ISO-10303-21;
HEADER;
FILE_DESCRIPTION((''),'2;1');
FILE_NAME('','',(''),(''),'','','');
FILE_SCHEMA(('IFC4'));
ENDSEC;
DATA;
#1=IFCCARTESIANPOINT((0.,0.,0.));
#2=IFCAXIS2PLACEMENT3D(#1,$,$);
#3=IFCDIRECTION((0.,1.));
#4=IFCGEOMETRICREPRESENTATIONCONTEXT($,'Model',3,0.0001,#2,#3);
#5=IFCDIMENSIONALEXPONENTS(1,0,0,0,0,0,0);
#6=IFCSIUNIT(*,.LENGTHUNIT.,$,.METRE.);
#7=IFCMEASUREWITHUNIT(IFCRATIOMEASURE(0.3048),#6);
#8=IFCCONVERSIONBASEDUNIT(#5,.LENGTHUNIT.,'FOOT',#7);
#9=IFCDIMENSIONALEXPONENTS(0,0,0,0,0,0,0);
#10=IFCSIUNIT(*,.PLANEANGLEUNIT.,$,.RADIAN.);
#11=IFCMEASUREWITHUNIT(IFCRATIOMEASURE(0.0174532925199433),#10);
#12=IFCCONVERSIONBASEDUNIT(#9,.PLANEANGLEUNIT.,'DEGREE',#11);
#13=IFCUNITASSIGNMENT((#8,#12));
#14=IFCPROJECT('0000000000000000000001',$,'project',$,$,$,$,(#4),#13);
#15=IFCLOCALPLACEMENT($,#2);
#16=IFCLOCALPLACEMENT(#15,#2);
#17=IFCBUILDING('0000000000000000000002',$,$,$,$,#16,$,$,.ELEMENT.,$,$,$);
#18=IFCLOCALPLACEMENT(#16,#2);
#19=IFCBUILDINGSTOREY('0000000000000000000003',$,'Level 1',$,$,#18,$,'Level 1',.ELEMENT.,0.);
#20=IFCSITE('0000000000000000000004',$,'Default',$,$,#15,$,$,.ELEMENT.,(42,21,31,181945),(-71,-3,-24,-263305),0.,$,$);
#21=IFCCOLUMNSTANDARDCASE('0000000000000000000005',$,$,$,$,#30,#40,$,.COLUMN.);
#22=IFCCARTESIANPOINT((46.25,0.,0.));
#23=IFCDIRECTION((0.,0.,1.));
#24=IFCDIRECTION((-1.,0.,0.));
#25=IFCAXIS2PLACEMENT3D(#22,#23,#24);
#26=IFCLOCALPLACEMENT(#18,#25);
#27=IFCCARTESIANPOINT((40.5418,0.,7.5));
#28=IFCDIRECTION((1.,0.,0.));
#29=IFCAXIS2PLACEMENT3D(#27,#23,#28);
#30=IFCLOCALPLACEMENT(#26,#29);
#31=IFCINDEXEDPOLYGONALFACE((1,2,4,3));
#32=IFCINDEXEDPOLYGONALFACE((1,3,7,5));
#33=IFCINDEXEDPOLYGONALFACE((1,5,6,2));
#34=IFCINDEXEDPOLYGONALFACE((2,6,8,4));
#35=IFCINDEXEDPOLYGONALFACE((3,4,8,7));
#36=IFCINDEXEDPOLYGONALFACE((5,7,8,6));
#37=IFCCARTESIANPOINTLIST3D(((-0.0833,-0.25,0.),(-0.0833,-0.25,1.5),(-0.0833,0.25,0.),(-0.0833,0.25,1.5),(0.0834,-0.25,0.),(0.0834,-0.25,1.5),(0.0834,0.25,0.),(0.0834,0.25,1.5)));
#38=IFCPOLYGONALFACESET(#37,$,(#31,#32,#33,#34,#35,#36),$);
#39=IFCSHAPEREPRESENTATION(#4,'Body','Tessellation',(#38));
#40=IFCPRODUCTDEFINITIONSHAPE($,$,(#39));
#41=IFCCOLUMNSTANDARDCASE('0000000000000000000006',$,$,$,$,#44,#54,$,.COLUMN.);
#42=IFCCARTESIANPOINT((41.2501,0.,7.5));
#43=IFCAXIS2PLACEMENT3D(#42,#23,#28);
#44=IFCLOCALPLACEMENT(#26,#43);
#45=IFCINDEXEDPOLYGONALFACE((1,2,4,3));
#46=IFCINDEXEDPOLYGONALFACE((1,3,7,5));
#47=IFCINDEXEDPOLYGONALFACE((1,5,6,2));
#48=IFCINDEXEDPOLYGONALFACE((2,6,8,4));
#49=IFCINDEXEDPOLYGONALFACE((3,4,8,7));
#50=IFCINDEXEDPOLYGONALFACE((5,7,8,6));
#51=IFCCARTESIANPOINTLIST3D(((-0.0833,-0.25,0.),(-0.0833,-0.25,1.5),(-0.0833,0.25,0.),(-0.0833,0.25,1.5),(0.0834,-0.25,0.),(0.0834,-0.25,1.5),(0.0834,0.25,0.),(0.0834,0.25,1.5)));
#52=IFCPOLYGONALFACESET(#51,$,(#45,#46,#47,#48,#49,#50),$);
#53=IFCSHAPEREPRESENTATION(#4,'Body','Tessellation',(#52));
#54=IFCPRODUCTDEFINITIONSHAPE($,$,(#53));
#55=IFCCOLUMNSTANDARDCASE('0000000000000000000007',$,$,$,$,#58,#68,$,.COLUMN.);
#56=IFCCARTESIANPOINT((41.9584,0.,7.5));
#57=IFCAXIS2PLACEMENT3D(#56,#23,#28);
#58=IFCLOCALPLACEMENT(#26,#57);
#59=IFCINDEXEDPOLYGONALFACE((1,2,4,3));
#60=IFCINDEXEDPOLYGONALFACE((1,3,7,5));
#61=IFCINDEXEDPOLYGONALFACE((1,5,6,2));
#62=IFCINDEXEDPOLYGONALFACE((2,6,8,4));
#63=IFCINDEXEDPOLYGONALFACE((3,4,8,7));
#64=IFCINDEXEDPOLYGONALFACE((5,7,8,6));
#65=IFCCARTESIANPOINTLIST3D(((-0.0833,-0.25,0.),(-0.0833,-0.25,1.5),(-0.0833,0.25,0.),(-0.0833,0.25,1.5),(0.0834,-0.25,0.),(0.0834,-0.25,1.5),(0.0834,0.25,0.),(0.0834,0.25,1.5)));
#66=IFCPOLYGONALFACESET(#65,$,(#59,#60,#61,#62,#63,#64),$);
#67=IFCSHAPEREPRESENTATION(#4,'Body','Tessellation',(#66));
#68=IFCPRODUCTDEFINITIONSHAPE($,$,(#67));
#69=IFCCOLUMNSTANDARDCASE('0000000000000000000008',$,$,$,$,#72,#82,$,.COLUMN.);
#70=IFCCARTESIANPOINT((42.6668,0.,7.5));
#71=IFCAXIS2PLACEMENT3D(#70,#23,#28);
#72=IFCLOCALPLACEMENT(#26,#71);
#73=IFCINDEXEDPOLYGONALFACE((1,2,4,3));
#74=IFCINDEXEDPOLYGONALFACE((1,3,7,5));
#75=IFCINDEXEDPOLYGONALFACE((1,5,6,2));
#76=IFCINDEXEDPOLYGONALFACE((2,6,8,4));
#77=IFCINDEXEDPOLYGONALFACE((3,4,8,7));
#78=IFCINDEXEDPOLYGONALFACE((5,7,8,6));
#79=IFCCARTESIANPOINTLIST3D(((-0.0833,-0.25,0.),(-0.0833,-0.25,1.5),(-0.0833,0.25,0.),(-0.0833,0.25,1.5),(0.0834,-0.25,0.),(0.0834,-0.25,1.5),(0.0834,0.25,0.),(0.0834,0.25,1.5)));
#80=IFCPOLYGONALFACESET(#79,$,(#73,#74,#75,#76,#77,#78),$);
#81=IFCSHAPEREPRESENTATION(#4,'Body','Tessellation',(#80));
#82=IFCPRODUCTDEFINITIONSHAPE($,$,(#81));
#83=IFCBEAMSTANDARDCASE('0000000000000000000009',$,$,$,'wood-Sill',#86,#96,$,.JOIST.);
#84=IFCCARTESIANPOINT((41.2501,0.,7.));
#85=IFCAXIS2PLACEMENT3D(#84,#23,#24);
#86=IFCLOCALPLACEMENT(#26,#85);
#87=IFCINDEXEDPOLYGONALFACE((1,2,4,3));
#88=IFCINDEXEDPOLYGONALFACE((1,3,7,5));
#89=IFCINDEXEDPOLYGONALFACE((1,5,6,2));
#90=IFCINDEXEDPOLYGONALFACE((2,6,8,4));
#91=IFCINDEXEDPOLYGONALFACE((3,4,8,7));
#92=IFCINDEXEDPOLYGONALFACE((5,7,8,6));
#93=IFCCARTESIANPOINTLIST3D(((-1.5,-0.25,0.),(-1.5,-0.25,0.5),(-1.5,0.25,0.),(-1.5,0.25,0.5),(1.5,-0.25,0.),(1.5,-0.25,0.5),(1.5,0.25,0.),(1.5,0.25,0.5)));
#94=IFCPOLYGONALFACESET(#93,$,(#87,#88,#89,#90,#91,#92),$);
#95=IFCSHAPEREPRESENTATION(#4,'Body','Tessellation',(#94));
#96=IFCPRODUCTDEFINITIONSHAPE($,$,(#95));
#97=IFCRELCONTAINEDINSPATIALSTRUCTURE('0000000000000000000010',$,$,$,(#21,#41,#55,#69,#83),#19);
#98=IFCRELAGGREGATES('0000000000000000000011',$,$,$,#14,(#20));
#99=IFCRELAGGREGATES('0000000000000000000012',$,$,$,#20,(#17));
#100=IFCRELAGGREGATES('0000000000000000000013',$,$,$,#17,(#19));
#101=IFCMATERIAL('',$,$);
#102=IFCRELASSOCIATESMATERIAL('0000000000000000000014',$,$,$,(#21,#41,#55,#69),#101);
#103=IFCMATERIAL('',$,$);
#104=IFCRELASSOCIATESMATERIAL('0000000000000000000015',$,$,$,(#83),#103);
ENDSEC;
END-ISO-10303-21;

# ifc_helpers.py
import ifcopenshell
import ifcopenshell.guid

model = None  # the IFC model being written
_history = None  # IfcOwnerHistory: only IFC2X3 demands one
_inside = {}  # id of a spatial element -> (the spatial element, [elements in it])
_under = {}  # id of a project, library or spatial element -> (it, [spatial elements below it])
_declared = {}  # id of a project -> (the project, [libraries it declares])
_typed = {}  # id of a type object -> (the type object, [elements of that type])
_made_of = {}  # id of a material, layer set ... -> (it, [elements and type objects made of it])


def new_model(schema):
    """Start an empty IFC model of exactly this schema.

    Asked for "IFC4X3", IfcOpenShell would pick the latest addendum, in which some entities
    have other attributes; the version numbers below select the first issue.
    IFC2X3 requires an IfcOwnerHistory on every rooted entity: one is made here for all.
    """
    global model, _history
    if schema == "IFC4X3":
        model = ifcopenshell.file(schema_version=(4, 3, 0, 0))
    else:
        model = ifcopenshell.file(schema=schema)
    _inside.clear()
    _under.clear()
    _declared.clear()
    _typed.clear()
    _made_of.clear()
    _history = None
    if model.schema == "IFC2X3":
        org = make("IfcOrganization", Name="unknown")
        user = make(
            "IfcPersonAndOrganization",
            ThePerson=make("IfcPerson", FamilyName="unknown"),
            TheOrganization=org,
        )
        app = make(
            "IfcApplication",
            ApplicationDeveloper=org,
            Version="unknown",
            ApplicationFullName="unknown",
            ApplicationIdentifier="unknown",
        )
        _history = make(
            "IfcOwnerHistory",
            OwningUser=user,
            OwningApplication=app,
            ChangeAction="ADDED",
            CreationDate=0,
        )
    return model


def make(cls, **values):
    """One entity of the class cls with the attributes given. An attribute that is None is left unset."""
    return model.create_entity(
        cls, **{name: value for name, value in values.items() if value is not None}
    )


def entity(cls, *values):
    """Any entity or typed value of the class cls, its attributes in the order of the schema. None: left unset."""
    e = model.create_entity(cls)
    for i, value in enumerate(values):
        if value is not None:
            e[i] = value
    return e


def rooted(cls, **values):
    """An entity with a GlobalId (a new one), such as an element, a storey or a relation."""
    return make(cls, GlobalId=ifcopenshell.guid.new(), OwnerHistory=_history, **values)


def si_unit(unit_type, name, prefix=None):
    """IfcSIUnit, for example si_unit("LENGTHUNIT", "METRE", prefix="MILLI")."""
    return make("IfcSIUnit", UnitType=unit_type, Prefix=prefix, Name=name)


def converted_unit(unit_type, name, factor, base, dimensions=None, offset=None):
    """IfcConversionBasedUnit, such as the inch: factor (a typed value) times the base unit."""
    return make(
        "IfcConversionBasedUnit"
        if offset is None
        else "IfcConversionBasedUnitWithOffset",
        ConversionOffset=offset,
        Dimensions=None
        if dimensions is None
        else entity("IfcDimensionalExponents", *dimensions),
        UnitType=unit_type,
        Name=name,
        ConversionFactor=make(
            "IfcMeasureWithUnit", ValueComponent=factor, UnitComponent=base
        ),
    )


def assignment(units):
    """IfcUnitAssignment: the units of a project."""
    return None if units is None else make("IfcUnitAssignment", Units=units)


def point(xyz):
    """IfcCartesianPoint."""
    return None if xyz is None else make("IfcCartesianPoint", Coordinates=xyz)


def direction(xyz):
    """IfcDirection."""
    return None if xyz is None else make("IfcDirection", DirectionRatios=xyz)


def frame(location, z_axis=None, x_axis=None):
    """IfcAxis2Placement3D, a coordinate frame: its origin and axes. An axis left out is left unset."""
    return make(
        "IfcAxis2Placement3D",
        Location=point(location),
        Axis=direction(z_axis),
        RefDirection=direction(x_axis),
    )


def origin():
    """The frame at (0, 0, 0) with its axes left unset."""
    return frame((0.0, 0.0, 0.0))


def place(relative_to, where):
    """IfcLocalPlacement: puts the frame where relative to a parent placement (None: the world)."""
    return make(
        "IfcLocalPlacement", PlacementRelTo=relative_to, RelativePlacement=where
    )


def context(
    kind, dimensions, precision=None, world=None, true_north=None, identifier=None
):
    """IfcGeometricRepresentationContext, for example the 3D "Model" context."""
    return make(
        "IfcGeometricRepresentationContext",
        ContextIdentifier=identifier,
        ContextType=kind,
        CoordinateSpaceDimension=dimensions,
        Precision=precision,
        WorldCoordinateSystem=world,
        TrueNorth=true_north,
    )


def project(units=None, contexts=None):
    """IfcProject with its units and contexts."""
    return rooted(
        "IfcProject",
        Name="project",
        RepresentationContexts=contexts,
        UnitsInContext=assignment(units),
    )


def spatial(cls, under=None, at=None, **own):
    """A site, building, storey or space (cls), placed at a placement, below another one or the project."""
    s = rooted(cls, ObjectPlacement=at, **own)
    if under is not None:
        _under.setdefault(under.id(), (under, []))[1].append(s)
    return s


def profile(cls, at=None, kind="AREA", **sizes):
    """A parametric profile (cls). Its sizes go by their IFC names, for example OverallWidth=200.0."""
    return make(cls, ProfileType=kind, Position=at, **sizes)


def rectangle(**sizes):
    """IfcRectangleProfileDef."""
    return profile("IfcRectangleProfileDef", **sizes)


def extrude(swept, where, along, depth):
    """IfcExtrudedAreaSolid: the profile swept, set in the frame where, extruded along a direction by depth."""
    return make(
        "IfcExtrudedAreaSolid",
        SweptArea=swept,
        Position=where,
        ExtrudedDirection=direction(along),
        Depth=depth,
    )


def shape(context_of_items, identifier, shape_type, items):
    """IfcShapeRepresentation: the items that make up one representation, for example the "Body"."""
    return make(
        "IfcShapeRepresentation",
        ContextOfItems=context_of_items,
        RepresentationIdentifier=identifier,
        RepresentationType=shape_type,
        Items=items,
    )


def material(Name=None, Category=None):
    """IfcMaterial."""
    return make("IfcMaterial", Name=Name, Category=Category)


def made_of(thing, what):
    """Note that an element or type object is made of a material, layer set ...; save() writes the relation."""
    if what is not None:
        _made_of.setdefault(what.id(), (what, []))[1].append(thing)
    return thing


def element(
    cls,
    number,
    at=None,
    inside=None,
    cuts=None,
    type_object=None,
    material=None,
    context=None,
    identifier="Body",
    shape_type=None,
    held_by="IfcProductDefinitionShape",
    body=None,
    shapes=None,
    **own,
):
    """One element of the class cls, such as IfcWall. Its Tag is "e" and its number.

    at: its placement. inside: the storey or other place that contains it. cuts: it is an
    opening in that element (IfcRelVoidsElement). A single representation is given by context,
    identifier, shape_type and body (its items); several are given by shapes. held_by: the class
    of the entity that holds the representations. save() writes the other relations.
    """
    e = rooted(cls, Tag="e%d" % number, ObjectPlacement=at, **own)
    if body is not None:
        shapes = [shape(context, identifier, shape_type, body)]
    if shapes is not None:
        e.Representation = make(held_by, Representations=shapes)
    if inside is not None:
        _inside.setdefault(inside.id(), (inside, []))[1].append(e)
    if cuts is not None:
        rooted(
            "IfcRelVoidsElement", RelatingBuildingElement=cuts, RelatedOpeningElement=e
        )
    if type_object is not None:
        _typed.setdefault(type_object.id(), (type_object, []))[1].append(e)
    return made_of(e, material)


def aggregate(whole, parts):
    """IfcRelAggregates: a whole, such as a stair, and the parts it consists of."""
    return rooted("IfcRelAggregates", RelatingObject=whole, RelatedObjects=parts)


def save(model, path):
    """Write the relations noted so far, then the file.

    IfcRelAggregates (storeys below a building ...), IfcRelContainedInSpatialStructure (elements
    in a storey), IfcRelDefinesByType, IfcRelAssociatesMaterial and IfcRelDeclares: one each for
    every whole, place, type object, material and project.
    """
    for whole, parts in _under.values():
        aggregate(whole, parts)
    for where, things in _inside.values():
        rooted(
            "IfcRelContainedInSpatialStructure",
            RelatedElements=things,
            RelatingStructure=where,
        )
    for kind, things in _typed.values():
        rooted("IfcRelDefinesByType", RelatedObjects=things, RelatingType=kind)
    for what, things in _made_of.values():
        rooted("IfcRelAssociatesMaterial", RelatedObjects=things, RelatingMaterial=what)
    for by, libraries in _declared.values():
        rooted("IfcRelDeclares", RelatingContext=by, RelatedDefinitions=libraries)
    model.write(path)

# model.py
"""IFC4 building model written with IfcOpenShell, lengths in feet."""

from ifc_helpers import new_model, entity, si_unit, converted_unit, direction, frame, origin, place, context, project, spatial, rectangle, extrude, material, element, save


model = new_model("IFC4")

# Units and contexts
model_context = context("Model", 3, precision=0.0001, world=origin(), true_north=direction((0.0, 1.0)))
ifc_project = project(units=[converted_unit("LENGTHUNIT", "FOOT", entity("IfcRatioMeasure", 0.3048), si_unit("LENGTHUNIT", "METRE"), dimensions=[1, 0, 0, 0, 0, 0, 0]), converted_unit("PLANEANGLEUNIT", "DEGREE", entity("IfcRatioMeasure", 0.0174532925199433), si_unit("PLANEANGLEUNIT", "RADIAN"), dimensions=[0, 0, 0, 0, 0, 0, 0])], contexts=[model_context])

# Site, building, storey
site_placement = place(None, origin())
site = spatial("IfcSite", under=ifc_project, at=site_placement, Name="Default", CompositionType="ELEMENT", RefLatitude=(42, 21, 31, 181945), RefLongitude=(-71, -3, -24, -263305), RefElevation=0.0)
building_placement = place(site_placement, origin())
building = spatial("IfcBuilding", under=site, at=building_placement, CompositionType="ELEMENT")
storey_placement = place(building_placement, origin())
storey = spatial("IfcBuildingStorey", under=building, at=storey_placement, Name="Level 1", LongName="Level 1", CompositionType="ELEMENT", Elevation=0.0)

# Columns
ifc_material_1 = material(Name="")
placement_1 = place(storey_placement, frame((46.25, 0.0, 0.0), z_axis=(0.0, 0.0, 1.0), x_axis=(-1.0, 0.0, 0.0)))
for number, where, z_axis, x_axis in (
    (1, (40.5418, 0.0, 7.5), (0.0, 0.0, 1.0), (1.0, 0.0, 0.0)),
    (2, (41.2501, 0.0, 7.5), (0.0, 0.0, 1.0), (1.0, 0.0, 0.0)),
    (3, (41.9584, 0.0, 7.5), (0.0, 0.0, 1.0), (1.0, 0.0, 0.0)),
    (4, (42.6668, 0.0, 7.5), (0.0, 0.0, 1.0), (1.0, 0.0, 0.0)),
):
    element("IfcColumnStandardCase", number, at=place(placement_1, frame(where, z_axis=z_axis, x_axis=x_axis)), inside=storey, material=ifc_material_1, PredefinedType="COLUMN", context=model_context, shape_type="SweptSolid", body=[
        extrude(rectangle(XDim=0.1667, YDim=0.5), origin(), (0.0, 0.0, 1.0), 1.5),
    ])

# Beam
ifc_material_2 = material(Name="")
for number, where, z_axis, x_axis in (
    (5, (41.2501, 0.0, 7.0), (0.0, 0.0, 1.0), (-1.0, 0.0, 0.0)),
):
    element("IfcBeamStandardCase", number, at=place(placement_1, frame(where, z_axis=z_axis, x_axis=x_axis)), inside=storey, material=ifc_material_2, ObjectType="wood-Sill", PredefinedType="JOIST", context=model_context, shape_type="SweptSolid", body=[
        extrude(rectangle(XDim=3.0, YDim=0.5), origin(), (0.0, 0.0, 1.0), 0.5),
    ])

save(model, "model.ifc")
